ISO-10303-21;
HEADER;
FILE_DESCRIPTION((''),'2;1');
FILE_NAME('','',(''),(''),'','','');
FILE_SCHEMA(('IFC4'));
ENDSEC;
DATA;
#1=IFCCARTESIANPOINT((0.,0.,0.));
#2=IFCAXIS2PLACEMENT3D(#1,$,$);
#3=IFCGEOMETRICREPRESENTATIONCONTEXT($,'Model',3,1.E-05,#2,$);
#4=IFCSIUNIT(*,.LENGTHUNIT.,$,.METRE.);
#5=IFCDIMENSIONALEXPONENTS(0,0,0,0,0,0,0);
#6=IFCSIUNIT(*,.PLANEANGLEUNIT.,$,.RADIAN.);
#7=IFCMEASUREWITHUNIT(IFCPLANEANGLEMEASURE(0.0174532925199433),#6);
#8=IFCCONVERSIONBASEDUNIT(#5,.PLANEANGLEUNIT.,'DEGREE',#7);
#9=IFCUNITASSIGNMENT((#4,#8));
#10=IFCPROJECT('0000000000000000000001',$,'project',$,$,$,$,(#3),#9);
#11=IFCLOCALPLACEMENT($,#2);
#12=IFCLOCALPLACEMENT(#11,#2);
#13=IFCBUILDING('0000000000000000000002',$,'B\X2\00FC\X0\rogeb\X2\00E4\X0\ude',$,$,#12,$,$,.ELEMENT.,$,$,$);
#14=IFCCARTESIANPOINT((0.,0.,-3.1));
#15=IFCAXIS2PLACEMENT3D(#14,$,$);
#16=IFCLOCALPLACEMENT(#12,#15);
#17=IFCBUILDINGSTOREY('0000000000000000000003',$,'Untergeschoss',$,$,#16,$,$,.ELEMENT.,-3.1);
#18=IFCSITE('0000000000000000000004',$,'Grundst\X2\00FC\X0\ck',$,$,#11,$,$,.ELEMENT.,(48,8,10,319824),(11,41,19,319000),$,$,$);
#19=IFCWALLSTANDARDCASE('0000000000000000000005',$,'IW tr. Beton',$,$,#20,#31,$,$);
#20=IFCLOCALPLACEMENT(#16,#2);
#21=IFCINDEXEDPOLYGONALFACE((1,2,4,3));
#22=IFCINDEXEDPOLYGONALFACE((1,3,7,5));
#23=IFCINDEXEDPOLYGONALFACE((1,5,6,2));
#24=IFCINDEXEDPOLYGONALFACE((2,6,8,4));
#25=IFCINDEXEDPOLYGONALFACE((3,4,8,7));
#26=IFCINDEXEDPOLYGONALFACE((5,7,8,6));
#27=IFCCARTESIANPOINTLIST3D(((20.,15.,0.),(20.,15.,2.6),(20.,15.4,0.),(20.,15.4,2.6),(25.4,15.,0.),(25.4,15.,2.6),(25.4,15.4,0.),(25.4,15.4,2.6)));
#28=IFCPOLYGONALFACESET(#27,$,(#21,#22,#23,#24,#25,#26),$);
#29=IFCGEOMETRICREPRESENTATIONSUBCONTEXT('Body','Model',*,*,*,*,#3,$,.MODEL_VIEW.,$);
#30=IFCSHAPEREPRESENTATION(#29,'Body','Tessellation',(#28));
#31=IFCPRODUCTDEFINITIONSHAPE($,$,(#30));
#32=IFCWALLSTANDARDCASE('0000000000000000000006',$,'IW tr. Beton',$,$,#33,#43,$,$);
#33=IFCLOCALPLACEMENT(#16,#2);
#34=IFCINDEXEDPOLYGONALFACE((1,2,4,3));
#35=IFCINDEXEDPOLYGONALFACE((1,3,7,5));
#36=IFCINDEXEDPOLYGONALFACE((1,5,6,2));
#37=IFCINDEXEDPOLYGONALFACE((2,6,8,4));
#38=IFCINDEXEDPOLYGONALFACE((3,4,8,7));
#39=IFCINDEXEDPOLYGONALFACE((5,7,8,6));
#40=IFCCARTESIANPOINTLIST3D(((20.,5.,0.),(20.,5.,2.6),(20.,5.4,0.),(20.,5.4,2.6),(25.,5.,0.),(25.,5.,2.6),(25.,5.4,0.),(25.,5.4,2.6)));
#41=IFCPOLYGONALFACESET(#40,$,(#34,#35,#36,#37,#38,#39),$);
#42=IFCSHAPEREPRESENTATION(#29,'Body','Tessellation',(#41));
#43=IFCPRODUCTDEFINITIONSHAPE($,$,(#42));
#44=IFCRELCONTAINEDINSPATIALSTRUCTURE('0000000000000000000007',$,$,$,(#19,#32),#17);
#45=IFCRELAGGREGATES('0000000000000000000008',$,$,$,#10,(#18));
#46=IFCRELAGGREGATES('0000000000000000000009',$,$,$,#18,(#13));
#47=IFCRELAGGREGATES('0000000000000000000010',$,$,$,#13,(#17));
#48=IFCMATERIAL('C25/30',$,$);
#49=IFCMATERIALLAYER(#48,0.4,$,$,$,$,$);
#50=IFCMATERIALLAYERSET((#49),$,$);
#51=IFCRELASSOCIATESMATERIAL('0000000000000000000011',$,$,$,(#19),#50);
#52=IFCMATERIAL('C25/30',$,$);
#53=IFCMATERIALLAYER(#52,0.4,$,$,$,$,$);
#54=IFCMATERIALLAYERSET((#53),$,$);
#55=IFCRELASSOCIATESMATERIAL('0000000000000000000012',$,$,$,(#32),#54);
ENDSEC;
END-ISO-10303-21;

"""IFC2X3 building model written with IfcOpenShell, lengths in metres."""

from ifc_helpers import new_model, entity, si_unit, converted_unit, frame, frame_2d, origin, origin_with_axes, place, context, subcontext, project, spatial, rectangle, extrude, material, layer, layer_set, layer_usage, element, save


model = new_model("IFC2X3")

# Units and contexts
model_context = context("Model", 3, precision=1e-05, world=origin())
body_context = subcontext(model_context, "Body", "Model", "MODEL_VIEW")
ifc_project = project(units=[si_unit("LENGTHUNIT", "METRE"), converted_unit("PLANEANGLEUNIT", "DEGREE", entity("IfcPlaneAngleMeasure", 0.0174532925199433), si_unit("PLANEANGLEUNIT", "RADIAN"), dimensions=[0, 0, 0, 0, 0, 0, 0])], contexts=[model_context])

# Site, building, storey
site_placement = place(None, origin())
site = spatial("IfcSite", under=ifc_project, at=site_placement, Name="Grundstück", CompositionType="ELEMENT", RefLatitude=(48, 8, 10, 319824), RefLongitude=(11, 41, 19, 319000))
building_placement = place(site_placement, origin())
building = spatial("IfcBuilding", under=site, at=building_placement, Name="Bürogebäude", CompositionType="ELEMENT")
storey_placement = place(building_placement, frame((0.0, 0.0, -3.1)))
storey = spatial("IfcBuildingStorey", under=building, at=storey_placement, Name="Untergeschoss", CompositionType="ELEMENT", Elevation=-3.1)

# Walls
ifc_material_1 = material(Name="C25/30")
ifc_layer_1 = layer(ifc_material_1, 0.4)
ifc_layer_set_1 = layer_set([ifc_layer_1])
ifc_layer_usage_1 = layer_usage(ifc_layer_set_1, "AXIS2", "POSITIVE", -0.2)
wall_1_placement = place(storey_placement, frame((20.0, 15.0, 0.0)))
element("IfcWallStandardCase", 1, at=wall_1_placement, inside=storey, material=ifc_layer_usage_1, Name="IW tr. Beton", context=body_context, shape_type="SweptSolid", body=[
    extrude(rectangle(XDim=5.4, YDim=0.4, at=frame_2d((2.7, 0.2), x_axis=(1.0, 0.0))), origin_with_axes(), (0.0, 0.0, 1.0), 2.6),
])
ifc_material_2 = material(Name="C25/30")
ifc_layer_2 = layer(ifc_material_2, 0.4)
ifc_layer_set_2 = layer_set([ifc_layer_2])
ifc_layer_usage_2 = layer_usage(ifc_layer_set_2, "AXIS2", "POSITIVE", -0.2)
wall_2_placement = place(storey_placement, frame((25.0, 5.4, 0.0), z_axis=(0.0, 0.0, 1.0), x_axis=(-1.0, 0.0, 0.0)))
element("IfcWallStandardCase", 2, at=wall_2_placement, inside=storey, material=ifc_layer_usage_2, Name="IW tr. Beton", context=body_context, shape_type="SweptSolid", body=[
    extrude(rectangle(XDim=5.0, YDim=0.4, at=frame_2d((2.5, 0.2), x_axis=(1.0, 0.0))), origin_with_axes(), (0.0, 0.0, 1.0), 2.6),
])

save(model, "model.ifc")
